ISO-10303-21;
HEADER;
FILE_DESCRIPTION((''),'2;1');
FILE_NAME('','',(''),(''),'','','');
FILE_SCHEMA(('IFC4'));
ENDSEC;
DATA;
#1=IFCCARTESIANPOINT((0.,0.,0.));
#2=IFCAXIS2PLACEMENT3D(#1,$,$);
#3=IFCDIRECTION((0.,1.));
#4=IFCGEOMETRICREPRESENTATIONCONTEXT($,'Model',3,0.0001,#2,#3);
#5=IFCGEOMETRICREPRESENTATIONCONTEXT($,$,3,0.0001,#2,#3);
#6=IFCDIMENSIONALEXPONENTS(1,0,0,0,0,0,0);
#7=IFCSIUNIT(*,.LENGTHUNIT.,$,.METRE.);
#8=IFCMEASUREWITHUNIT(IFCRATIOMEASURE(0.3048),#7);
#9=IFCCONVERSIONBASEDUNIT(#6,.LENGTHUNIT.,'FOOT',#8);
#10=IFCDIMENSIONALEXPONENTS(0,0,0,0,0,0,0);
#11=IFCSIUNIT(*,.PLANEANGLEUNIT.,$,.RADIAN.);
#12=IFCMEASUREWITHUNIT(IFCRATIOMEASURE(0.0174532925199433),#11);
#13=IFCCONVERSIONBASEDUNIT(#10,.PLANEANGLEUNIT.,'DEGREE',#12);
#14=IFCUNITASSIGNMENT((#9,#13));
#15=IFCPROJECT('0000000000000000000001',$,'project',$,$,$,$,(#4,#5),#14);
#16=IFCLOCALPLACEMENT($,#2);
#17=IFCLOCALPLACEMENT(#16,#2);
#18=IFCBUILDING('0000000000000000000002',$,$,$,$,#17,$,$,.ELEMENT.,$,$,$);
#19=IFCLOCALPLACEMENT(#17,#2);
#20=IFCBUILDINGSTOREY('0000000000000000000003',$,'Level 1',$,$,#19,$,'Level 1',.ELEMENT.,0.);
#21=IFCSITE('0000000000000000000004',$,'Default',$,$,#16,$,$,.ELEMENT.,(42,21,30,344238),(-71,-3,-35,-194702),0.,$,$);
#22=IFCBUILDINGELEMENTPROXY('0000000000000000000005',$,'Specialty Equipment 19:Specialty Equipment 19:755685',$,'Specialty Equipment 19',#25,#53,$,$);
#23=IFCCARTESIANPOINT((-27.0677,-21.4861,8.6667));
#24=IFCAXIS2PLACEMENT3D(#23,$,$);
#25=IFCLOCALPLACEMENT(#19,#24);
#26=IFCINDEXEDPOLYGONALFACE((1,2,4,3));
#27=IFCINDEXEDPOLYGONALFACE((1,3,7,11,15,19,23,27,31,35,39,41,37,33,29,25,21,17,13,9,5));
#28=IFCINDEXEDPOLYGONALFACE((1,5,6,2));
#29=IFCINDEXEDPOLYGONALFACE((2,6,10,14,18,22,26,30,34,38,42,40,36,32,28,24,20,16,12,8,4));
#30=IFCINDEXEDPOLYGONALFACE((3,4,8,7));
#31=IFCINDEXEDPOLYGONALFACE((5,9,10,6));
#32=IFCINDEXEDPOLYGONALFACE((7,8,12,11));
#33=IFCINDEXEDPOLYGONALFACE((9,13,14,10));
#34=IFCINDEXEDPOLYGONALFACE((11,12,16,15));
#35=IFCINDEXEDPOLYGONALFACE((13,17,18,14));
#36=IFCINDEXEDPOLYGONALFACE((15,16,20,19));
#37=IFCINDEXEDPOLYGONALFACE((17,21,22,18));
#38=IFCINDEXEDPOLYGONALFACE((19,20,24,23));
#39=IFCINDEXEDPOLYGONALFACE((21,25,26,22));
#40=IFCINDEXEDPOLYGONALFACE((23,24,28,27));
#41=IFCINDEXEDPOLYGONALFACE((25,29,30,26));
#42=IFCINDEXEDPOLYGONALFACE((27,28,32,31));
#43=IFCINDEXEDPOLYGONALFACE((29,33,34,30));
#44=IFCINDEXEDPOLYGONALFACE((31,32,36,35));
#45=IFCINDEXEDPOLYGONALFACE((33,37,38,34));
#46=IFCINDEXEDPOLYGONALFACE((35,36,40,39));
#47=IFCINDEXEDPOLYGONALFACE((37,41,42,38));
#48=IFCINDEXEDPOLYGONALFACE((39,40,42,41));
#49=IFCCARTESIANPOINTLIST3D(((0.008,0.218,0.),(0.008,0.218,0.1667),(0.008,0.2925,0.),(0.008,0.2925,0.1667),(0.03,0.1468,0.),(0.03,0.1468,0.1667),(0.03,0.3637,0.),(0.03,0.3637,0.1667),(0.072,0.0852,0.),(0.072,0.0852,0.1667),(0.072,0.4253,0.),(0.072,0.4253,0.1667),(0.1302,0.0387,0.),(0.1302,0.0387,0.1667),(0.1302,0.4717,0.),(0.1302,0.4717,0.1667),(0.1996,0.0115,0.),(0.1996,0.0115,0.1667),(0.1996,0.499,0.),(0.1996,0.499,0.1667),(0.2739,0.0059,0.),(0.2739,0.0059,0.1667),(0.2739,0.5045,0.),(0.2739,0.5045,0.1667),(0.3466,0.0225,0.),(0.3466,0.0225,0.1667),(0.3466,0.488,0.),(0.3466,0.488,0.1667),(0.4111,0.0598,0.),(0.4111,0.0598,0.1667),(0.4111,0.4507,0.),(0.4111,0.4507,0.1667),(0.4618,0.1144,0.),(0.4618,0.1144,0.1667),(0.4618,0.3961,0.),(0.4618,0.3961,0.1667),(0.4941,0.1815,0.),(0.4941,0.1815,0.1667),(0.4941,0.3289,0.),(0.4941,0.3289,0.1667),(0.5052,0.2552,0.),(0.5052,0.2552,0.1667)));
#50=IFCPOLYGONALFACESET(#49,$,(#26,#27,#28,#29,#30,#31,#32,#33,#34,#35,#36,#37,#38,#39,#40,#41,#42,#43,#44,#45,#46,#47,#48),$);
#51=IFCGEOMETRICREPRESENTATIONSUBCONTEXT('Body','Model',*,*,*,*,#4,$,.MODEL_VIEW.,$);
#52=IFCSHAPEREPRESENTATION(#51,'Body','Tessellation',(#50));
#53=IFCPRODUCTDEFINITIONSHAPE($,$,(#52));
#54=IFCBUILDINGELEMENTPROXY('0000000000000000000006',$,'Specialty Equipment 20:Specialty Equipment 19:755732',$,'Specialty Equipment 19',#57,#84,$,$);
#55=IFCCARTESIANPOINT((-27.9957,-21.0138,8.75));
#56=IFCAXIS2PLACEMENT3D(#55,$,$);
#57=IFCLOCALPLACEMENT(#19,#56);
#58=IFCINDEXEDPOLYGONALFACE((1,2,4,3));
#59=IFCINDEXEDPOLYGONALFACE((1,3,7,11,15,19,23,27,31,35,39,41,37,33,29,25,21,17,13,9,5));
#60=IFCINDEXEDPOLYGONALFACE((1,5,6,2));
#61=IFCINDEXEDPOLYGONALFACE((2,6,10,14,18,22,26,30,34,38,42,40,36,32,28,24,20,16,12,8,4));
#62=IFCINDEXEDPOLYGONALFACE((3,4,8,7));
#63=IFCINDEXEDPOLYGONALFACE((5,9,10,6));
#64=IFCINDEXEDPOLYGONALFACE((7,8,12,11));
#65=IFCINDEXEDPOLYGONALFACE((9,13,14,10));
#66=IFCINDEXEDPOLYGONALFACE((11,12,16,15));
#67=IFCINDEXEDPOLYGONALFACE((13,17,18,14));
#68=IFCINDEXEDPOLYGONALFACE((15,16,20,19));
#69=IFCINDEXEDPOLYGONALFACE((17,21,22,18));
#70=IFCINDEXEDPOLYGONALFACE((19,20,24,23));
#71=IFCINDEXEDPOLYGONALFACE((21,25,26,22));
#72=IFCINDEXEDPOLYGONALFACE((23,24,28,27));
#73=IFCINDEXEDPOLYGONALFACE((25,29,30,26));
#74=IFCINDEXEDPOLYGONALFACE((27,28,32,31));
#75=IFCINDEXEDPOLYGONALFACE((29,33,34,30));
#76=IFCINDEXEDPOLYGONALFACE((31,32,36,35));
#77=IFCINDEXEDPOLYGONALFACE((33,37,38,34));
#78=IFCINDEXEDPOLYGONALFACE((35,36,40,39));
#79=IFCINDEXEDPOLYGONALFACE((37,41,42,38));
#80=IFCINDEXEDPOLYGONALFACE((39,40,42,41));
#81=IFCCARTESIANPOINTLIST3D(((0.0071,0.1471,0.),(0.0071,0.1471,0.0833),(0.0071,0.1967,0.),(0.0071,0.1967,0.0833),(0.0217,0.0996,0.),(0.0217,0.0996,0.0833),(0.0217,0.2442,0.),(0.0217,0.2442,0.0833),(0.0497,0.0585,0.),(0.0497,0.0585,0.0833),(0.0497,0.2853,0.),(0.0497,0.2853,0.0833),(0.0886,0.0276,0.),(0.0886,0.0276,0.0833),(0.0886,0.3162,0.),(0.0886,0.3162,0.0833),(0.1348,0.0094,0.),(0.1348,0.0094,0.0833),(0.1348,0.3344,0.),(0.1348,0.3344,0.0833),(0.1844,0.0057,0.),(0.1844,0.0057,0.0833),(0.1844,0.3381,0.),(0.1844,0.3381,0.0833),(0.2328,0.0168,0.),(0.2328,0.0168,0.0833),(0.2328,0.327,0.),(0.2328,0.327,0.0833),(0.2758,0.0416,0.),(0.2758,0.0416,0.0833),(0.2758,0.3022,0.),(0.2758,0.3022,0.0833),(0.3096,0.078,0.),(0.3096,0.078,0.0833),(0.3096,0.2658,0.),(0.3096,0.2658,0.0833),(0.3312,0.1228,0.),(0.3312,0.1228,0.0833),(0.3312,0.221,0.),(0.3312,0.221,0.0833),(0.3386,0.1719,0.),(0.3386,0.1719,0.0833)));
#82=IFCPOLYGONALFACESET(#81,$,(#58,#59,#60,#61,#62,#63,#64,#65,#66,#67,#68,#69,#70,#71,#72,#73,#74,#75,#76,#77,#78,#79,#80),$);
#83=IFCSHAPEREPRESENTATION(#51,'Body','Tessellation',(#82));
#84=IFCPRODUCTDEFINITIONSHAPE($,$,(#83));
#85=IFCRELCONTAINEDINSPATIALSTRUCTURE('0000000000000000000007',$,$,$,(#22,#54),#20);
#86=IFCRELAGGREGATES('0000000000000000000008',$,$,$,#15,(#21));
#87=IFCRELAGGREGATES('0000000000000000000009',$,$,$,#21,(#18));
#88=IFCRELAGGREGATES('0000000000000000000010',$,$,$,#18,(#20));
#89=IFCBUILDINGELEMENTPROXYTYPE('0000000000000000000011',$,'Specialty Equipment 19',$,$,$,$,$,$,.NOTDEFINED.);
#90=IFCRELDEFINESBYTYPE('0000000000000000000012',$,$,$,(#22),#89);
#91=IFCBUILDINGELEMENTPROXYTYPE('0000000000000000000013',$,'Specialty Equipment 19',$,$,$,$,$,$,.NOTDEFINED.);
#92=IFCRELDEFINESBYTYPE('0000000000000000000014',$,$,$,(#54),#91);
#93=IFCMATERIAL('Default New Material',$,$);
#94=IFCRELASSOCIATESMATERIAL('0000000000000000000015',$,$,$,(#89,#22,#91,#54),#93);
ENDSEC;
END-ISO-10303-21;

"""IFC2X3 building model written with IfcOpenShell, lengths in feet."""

from ifc_helpers import new_model, entity, si_unit, converted_unit, direction, frame, origin, origin_2d_with_axis, place, context, subcontext, project, spatial, circle, extrude, source, transform, mapped, material, type_object, type_shapes, element, save


model = new_model("IFC2X3")

# Units and contexts
model_context = context("Model", 3, precision=0.0001, world=origin(), true_north=direction((0.0, 1.0)))
context_of_model = context(None, 3, precision=0.0001, world=origin(), true_north=direction((0.0, 1.0)))
body_context = subcontext(model_context, "Body", "Model", "MODEL_VIEW")
ifc_project = project(units=[converted_unit("LENGTHUNIT", "FOOT", entity("IfcRatioMeasure", 0.3048), si_unit("LENGTHUNIT", "METRE"), dimensions=[1, 0, 0, 0, 0, 0, 0]), converted_unit("PLANEANGLEUNIT", "DEGREE", entity("IfcRatioMeasure", 0.0174532925199433), si_unit("PLANEANGLEUNIT", "RADIAN"), dimensions=[0, 0, 0, 0, 0, 0, 0])], contexts=[model_context, context_of_model])

# Site, building, storey
site_placement = place(None, origin())
site = spatial("IfcSite", under=ifc_project, at=site_placement, Name="Default", CompositionType="ELEMENT", RefLatitude=(42, 21, 30, 344238), RefLongitude=(-71, -3, -35, -194702), RefElevation=0.0)
building_placement = place(site_placement, origin())
building = spatial("IfcBuilding", under=site, at=building_placement, CompositionType="ELEMENT")
storey_placement = place(building_placement, origin())
storey = spatial("IfcBuildingStorey", under=building, at=storey_placement, Name="Level 1", LongName="Level 1", CompositionType="ELEMENT", Elevation=0.0)

# Shared definitions
ifc_material_1 = material(Name="Default New Material")

# Building element proxies
building_element_proxy_type_1 = type_object("IfcBuildingElementProxyType", Name="Specialty Equipment 19", PredefinedType="NOTDEFINED", material=ifc_material_1)
shared_shape_1 = source(origin(), body_context, "Body", "SweptSolid", [
    extrude(circle(Radius=0.25, at=origin_2d_with_axis()), frame((0.2552, 0.2552, 0.0)), (0.0, 0.0, 1.0), 0.1667),
])
type_shapes(building_element_proxy_type_1, [shared_shape_1])
proxy_1_placement = place(storey_placement, frame((-27.0677, -21.4861, 8.6667)))
element("IfcBuildingElementProxy", 1, at=proxy_1_placement, inside=storey, type_object=building_element_proxy_type_1, material=ifc_material_1, Name="Specialty Equipment 19:Specialty Equipment 19:755685", ObjectType="Specialty Equipment 19", context=body_context, shape_type="MappedRepresentation", body=[
    mapped(shared_shape_1, transform((0.0, 0.0, 0.0), scale=1.0)),
])
building_element_proxy_type_2 = type_object("IfcBuildingElementProxyType", Name="Specialty Equipment 19", PredefinedType="NOTDEFINED", material=ifc_material_1)
shared_shape_2 = source(origin(), body_context, "Body", "SweptSolid", [
    extrude(circle(Radius=0.1667, at=origin_2d_with_axis()), frame((0.1719, 0.1719, 0.0)), (0.0, 0.0, 1.0), 0.0833),
])
type_shapes(building_element_proxy_type_2, [shared_shape_2])
proxy_2_placement = place(storey_placement, frame((-27.9957, -21.0138, 8.75)))
element("IfcBuildingElementProxy", 2, at=proxy_2_placement, inside=storey, type_object=building_element_proxy_type_2, material=ifc_material_1, Name="Specialty Equipment 20:Specialty Equipment 19:755732", ObjectType="Specialty Equipment 19", context=body_context, shape_type="MappedRepresentation", body=[
    mapped(shared_shape_2, transform((0.0, 0.0, 0.0), scale=1.0)),
])

save(model, "model.ifc")
